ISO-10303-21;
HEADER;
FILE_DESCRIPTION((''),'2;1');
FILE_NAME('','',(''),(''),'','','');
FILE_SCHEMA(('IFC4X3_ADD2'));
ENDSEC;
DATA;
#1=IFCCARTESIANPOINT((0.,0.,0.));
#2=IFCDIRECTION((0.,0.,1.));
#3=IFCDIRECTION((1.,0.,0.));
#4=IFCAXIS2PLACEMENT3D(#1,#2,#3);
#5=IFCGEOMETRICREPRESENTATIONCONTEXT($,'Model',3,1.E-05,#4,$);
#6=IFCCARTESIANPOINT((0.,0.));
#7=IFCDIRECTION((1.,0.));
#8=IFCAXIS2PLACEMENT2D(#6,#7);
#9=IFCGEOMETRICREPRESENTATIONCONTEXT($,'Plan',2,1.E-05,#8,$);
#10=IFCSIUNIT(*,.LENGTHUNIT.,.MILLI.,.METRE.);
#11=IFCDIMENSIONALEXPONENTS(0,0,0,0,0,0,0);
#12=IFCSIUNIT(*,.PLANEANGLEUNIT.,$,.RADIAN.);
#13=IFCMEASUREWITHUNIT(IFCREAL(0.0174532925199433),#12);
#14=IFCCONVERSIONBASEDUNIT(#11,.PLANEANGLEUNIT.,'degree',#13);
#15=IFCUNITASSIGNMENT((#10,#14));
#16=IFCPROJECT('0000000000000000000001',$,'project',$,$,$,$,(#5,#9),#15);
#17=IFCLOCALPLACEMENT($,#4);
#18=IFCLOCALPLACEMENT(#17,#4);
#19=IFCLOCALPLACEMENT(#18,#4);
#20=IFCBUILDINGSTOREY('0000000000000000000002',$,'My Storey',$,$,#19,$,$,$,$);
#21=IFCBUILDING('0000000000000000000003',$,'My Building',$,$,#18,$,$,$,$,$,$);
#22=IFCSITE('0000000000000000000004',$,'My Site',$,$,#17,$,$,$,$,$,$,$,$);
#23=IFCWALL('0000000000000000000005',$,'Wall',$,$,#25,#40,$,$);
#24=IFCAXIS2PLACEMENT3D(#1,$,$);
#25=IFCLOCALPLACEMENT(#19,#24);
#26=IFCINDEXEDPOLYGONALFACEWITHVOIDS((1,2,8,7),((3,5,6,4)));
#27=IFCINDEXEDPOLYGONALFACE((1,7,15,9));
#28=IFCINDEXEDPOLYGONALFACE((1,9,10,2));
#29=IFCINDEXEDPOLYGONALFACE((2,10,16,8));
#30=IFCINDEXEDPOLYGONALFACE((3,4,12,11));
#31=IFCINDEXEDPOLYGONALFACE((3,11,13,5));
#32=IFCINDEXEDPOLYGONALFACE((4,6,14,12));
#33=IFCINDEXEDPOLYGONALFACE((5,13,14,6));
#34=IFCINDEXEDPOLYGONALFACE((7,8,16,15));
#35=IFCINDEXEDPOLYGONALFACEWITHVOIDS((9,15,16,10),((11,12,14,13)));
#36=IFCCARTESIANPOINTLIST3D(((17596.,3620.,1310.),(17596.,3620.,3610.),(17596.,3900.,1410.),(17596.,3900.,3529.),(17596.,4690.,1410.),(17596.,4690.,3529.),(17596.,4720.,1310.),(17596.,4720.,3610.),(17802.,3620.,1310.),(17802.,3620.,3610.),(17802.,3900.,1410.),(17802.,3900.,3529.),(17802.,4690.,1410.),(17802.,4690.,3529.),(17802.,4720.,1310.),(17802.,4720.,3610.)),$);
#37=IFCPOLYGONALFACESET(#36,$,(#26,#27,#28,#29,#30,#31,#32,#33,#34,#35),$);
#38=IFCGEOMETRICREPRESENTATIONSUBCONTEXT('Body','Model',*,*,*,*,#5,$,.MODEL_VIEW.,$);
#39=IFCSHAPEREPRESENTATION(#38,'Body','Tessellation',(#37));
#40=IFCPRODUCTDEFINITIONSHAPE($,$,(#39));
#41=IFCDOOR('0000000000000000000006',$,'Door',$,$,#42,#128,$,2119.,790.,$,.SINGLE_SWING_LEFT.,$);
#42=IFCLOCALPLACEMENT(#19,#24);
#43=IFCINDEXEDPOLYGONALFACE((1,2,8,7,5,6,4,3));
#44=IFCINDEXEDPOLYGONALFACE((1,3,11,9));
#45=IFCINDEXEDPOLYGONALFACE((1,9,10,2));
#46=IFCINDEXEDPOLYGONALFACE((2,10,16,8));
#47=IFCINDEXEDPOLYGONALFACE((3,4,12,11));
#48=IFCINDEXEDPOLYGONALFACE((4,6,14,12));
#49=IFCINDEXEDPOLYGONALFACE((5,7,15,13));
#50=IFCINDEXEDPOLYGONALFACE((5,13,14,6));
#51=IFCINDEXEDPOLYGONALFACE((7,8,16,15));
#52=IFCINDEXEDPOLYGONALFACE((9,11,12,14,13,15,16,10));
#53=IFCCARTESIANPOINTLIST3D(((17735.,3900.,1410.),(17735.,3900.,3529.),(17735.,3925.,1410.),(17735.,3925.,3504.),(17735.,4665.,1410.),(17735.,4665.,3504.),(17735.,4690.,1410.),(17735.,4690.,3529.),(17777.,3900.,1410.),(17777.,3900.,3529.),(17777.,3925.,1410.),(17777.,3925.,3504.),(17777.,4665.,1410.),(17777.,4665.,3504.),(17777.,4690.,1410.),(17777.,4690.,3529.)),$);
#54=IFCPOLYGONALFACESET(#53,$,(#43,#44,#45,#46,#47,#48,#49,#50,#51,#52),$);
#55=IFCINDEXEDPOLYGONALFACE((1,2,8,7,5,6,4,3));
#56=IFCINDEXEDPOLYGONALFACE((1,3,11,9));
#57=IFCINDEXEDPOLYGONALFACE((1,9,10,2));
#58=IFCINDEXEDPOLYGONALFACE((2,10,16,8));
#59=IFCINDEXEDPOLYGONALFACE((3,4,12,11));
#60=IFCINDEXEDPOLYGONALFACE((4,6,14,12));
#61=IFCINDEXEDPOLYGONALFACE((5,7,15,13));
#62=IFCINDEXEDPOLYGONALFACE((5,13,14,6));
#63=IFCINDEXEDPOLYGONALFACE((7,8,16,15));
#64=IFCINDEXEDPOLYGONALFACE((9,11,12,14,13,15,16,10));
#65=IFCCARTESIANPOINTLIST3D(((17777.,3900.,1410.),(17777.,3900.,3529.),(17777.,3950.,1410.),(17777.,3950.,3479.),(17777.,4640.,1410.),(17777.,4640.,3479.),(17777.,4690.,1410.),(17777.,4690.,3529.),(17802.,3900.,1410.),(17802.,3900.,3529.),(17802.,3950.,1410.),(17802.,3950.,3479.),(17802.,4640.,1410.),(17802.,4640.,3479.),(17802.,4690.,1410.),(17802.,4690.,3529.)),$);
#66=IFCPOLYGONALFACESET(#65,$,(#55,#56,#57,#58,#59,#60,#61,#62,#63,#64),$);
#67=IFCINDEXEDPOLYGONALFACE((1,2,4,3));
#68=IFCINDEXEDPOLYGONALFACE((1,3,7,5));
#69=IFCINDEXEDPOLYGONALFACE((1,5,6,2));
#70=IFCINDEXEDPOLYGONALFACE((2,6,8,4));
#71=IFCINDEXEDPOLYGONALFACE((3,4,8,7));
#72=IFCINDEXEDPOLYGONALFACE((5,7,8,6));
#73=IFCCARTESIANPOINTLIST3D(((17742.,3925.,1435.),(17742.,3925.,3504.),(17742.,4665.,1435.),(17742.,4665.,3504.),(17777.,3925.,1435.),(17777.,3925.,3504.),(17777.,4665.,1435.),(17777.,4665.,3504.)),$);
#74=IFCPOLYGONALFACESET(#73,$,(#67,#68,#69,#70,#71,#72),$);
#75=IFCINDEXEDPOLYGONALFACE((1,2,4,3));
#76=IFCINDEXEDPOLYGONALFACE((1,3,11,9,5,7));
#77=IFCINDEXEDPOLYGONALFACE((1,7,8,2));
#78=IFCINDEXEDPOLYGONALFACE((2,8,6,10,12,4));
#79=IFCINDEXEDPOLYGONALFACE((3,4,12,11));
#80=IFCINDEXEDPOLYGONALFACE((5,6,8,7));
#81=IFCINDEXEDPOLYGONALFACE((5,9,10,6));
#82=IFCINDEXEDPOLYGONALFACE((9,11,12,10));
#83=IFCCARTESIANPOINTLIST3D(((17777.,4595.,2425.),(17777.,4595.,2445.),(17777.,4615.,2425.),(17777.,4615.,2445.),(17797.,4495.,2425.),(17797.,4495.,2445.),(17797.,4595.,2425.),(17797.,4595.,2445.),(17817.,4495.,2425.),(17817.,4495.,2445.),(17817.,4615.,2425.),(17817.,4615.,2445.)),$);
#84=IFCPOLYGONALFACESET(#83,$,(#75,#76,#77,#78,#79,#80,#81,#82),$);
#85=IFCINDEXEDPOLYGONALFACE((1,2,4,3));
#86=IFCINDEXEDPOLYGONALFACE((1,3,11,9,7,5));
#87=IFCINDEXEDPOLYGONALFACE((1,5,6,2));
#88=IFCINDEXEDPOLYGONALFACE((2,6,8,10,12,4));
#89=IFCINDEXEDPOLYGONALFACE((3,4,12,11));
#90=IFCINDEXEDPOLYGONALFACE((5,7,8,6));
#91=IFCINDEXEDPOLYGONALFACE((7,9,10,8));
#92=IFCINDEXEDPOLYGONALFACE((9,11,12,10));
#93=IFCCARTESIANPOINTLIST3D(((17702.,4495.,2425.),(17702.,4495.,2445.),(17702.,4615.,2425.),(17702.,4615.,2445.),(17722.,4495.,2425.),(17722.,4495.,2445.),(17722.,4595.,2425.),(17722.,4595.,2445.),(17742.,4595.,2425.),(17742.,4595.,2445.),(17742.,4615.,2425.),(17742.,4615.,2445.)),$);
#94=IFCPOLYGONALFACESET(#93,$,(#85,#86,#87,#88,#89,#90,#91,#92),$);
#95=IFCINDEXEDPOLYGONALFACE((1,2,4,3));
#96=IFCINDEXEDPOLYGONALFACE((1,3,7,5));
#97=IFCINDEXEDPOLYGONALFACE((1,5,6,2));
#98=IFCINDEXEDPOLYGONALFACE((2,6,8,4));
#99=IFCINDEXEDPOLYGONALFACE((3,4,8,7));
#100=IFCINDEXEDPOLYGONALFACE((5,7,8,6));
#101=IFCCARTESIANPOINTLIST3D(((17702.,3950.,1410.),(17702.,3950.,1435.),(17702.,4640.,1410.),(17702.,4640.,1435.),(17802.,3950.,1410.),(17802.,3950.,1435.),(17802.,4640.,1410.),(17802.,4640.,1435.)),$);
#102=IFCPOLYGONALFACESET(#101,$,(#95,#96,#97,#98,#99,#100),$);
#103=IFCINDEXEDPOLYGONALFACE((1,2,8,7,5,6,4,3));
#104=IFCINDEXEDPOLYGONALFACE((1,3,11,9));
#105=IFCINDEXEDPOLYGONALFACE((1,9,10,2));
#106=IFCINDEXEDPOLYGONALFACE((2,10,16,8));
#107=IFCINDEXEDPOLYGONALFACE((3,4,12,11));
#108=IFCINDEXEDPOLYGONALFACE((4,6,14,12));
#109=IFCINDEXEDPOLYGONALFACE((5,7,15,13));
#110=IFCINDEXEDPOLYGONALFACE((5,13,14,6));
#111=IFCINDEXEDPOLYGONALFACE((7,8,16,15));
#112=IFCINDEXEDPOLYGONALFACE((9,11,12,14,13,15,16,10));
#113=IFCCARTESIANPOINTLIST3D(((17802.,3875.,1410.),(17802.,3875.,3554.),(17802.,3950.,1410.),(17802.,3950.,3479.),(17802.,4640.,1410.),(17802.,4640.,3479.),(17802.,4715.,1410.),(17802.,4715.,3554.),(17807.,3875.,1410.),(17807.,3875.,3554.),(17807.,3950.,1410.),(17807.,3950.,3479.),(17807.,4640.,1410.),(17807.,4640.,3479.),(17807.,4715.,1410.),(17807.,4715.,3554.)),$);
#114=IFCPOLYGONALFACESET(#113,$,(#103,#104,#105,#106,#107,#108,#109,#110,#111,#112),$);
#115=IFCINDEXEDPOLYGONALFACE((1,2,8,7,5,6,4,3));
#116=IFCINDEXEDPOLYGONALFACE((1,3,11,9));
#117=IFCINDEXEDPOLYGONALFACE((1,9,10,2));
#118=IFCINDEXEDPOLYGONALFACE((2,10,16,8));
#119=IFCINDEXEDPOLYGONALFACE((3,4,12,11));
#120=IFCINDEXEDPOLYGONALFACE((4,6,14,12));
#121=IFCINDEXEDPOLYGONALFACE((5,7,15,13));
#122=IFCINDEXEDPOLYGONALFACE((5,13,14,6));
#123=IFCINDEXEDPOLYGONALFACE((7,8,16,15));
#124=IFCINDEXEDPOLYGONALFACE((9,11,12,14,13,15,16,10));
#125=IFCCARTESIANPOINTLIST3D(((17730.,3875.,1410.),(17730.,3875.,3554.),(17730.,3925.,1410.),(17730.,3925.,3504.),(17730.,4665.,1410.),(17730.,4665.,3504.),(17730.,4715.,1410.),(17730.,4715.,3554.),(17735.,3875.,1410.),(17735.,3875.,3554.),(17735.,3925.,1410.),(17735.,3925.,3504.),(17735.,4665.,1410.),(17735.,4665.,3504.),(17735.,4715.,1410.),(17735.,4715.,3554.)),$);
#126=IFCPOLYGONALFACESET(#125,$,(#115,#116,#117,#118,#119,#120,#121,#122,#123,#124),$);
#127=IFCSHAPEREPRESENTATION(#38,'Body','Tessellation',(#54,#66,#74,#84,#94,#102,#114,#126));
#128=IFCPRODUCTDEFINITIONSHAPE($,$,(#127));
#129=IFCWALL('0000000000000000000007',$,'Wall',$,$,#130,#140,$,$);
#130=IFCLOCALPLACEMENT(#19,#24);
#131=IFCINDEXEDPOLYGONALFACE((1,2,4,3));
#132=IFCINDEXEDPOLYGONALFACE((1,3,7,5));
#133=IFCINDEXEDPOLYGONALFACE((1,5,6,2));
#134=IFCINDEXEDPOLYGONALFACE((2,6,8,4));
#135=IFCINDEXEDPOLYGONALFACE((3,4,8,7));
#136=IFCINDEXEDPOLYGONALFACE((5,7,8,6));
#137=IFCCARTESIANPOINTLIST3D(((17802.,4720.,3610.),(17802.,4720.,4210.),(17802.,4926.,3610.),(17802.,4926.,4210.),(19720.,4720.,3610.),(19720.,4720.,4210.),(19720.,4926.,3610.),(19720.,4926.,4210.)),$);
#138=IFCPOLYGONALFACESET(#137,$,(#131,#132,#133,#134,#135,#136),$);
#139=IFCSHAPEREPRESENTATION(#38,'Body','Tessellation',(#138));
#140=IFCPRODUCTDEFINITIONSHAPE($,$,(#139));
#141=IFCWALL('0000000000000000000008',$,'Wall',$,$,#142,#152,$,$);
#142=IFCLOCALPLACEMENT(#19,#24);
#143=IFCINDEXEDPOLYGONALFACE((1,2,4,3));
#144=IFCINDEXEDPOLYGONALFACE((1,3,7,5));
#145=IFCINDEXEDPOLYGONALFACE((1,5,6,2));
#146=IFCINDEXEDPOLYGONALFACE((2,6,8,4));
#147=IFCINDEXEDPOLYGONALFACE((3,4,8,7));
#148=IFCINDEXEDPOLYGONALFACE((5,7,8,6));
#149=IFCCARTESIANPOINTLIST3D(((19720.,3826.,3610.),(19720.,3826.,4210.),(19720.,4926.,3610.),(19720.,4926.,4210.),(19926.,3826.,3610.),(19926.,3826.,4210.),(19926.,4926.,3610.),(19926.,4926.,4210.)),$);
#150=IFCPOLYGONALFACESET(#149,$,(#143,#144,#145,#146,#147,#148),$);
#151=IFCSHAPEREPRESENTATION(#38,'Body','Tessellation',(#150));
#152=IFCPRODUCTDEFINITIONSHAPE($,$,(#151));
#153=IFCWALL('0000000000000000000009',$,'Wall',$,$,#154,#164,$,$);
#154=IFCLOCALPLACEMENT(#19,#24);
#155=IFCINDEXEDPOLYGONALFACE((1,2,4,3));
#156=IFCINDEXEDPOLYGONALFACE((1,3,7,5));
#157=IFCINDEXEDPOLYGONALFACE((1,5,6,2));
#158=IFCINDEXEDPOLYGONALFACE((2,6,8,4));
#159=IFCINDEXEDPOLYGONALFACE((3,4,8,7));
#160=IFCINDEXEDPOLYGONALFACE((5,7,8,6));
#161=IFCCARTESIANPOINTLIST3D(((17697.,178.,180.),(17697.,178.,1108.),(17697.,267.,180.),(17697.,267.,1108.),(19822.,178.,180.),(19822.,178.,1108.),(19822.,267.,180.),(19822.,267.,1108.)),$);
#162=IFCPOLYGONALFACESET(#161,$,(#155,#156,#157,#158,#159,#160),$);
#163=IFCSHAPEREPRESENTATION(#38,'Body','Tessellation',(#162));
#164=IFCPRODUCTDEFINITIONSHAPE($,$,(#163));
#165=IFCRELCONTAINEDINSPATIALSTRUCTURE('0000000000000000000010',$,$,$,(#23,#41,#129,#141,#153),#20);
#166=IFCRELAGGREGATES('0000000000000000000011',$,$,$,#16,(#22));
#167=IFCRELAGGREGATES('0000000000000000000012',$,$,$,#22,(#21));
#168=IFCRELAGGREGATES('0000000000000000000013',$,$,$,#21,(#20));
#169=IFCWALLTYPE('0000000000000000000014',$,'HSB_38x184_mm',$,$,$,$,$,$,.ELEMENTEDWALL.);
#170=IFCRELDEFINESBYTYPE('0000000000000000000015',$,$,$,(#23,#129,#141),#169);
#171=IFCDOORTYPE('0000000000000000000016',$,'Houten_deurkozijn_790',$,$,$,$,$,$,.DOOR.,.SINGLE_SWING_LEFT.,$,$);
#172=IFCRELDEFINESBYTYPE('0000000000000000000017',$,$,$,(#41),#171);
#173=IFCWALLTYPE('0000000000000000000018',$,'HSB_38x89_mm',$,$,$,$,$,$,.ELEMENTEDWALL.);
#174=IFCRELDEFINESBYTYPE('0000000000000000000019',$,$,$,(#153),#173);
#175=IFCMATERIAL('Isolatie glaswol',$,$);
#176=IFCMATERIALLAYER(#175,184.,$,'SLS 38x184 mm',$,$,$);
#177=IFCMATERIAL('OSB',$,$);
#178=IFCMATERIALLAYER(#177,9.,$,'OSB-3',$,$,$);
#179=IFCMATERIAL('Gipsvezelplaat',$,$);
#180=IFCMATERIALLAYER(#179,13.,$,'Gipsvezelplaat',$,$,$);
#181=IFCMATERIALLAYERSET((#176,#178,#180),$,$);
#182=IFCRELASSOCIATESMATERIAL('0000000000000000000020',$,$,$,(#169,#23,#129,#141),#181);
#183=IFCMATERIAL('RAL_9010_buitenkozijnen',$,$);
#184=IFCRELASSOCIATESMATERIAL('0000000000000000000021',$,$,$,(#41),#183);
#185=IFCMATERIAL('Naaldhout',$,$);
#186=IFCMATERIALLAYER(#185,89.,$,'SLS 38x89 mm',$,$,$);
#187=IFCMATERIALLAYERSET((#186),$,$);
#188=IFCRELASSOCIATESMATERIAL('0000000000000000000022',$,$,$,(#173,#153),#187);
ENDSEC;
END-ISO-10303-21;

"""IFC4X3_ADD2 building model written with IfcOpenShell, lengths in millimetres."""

from ifc_helpers import new_model, entity, si_unit, converted_unit, frame, origin_with_axes, origin_2d_with_axis, place, context, subcontext, project, spatial, line, indexed_curve, outline, extrude, shape, source, transform, mapped, material, layer, layer_set, layer_usage, type_object, type_shapes, element, fill, save


model = new_model("IFC4X3_ADD2")

# Units and contexts
model_context = context("Model", 3, precision=1e-05, world=origin_with_axes())
plan_context = context("Plan", 2, precision=1e-05, world=origin_2d_with_axis())
body_context_1 = subcontext(model_context, "Body", "Model", "MODEL_VIEW")
body_context_2 = subcontext(plan_context, "Body", "Plan", "PLAN_VIEW")
ifc_project = project(units=[si_unit("LENGTHUNIT", "METRE", prefix="MILLI"), converted_unit("PLANEANGLEUNIT", "degree", entity("IfcReal", 0.0174532925199433), si_unit("PLANEANGLEUNIT", "RADIAN"), dimensions=[0, 0, 0, 0, 0, 0, 0])], contexts=[model_context, plan_context])

# Site, building, storey
site_placement = place(None, origin_with_axes())
site = spatial("IfcSite", under=ifc_project, at=site_placement, Name="My Site")
building_placement = place(site_placement, origin_with_axes())
building = spatial("IfcBuilding", under=site, at=building_placement, Name="My Building")
storey_placement = place(building_placement, origin_with_axes())
storey = spatial("IfcBuildingStorey", under=building, at=storey_placement, Name="My Storey")

# Shared definitions
ifc_material_1 = material(Name="Isolatie glaswol")

# Shared definitions
ifc_layer_1 = layer(ifc_material_1, 184.0, Name="SLS 38x184 mm")
ifc_material_2 = material(Name="OSB")
ifc_layer_2 = layer(ifc_material_2, 9.0, Name="OSB-3")
ifc_material_3 = material(Name="Gipsvezelplaat")
ifc_layer_3 = layer(ifc_material_3, 13.0, Name="Gipsvezelplaat")
ifc_layer_set_1 = layer_set([ifc_layer_1, ifc_layer_2, ifc_layer_3])
wall_type_1 = type_object("IfcWallType", Name="HSB_38x184_mm", PredefinedType="ELEMENTEDWALL", material=ifc_layer_set_1)
ifc_material_4 = material(Name="RAL_9010_buitenkozijnen")

# Wall, opening, door
ifc_layer_usage_1 = layer_usage(ifc_layer_set_1, "AXIS2", "POSITIVE", 0.0)
wall_1_placement = place(storey_placement, frame((17802.0, 3620.0, 1310.0), z_axis=(0.0, 0.0, 1.0), x_axis=(0.0, 1.0, 0.0)))
wall_1 = element("IfcWall", 1, at=wall_1_placement, inside=storey, type_object=wall_type_1, material=ifc_layer_usage_1, Name="Wall", context=body_context_1, shape_type="SweptSolid", body=[
    extrude(outline(indexed_curve([(0.0, 0.0), (0.0, 206.0), (1100.0, 206.0), (1100.0, 0.0), (0.0, 0.0)], self_intersect=False)), origin_with_axes(), (0.0, 0.0, 1.0), 2300.0),
])
shared_shape_1 = source(origin_with_axes(), body_context_1, "Body", "SweptSolid", [
    extrude(outline(indexed_curve([(0.0, 0.0), (790.0, 0.0), (790.0, 2119.0), (0.0, 2119.0)], segments=[line(1, 2, 3, 4, 1)])), frame((0.0, -600.0, 0.0), z_axis=(0.0, -1.0, 0.0), x_axis=(1.0, 0.0, 0.0)), (0.0, 0.0, -1.0), 1200.0),
])
opening_1_placement = place(wall_1_placement, frame((280.0, 0.0, 100.0), z_axis=(0.0, 0.0, 1.0), x_axis=(1.0, 0.0, 0.0)))
opening_1 = element("IfcOpeningElement", 2, at=opening_1_placement, cuts=wall_1, PredefinedType="OPENING", context=body_context_1, shape_type="MappedRepresentation", body=[
    mapped(shared_shape_1, transform((0.0, 0.0, 0.0), x_axis=(1.0, 0.0, 0.0), y_axis=(0.0, 1.0, 0.0), z_axis=(0.0, 0.0, 1.0), scale=1.0)),
])
door_type_1 = type_object("IfcDoorType", Name="Houten_deurkozijn_790", OperationType="SINGLE_SWING_LEFT", PredefinedType="DOOR")
shared_shape_2 = source(origin_with_axes(), body_context_1, "Body", "SweptSolid", [
    extrude(outline(indexed_curve([(0.0, 0.0), (0.0, 2119.0), (790.0, 2119.0), (790.0, 0.0), (765.0, 0.0), (765.0, 2094.0), (25.0, 2094.0), (25.0, 0.0)], segments=[line(1, 2, 3, 4, 5, 6, 7, 8, 1)])), frame((0.0, 25.0, 0.0), z_axis=(0.0, -1.0, 0.0), x_axis=(1.0, 0.0, 0.0)), (0.0, 0.0, -1.0), 42.0),
    extrude(outline(indexed_curve([(0.0, 0.0), (0.0, 2119.0), (790.0, 2119.0), (790.0, 0.0), (740.0, 0.0), (740.0, 2069.0), (50.0, 2069.0), (50.0, 0.0)], segments=[line(1, 2, 3, 4, 5, 6, 7, 8, 1)])), frame((0.0, 0.0, 0.0), z_axis=(0.0, -1.0, 0.0), x_axis=(1.0, 0.0, 0.0)), (0.0, 0.0, -1.0), 25.0),
    extrude(outline(indexed_curve([(0.0, 0.0), (740.0, 0.0), (740.0, 35.0), (0.0, 35.0)], segments=[line(1, 2, 3, 4, 1)])), frame((25.0, 25.0, 25.0), z_axis=(0.0, 0.0, 1.0), x_axis=(1.0, 0.0, 0.0)), (0.0, 0.0, 1.0), 2069.0),
    extrude(outline(indexed_curve([(0.0, 0.0), (0.0, -40.0), (-120.0, -40.0), (-120.0, -20.0), (-20.0, -20.0), (-20.0, 0.0)], segments=[line(1, 2, 3, 4, 5, 6, 1)])), frame((715.0, 25.0, 1015.0), z_axis=(0.0, 0.0, 1.0), x_axis=(1.0, 0.0, 0.0)), (0.0, 0.0, 1.0), 20.0),
    extrude(outline(indexed_curve([(0.0, 0.0), (0.0, 40.0), (-120.0, 40.0), (-120.0, 20.0), (-20.0, 20.0), (-20.0, 0.0)], segments=[line(1, 2, 3, 4, 5, 6, 1)])), frame((715.0, 60.0, 1015.0), z_axis=(0.0, 0.0, 1.0), x_axis=(1.0, 0.0, 0.0)), (0.0, 0.0, 1.0), 20.0),
    extrude(outline(indexed_curve([(0.0, 0.0), (690.0, 0.0), (690.0, 100.0), (0.0, 100.0)], segments=[line(1, 2, 3, 4, 1)])), frame((50.0, 0.0, 0.0), z_axis=(0.0, 0.0, 1.0), x_axis=(1.0, 0.0, 0.0)), (0.0, 0.0, 1.0), 25.0),
    extrude(outline(indexed_curve([(0.0, 0.0), (0.0, 2144.0), (840.0, 2144.0), (840.0, 0.0), (765.0, 0.0), (765.0, 2069.0), (75.0, 2069.0), (75.0, 0.0)], segments=[line(1, 2, 3, 4, 5, 6, 7, 8, 1)])), frame((-25.0, -5.0, 0.0), z_axis=(0.0, -1.0, 0.0), x_axis=(1.0, 0.0, 0.0)), (0.0, 0.0, -1.0), 5.0),
    extrude(outline(indexed_curve([(0.0, 0.0), (0.0, 2144.0), (840.0, 2144.0), (840.0, 0.0), (790.0, 0.0), (790.0, 2094.0), (50.0, 2094.0), (50.0, 0.0)], segments=[line(1, 2, 3, 4, 5, 6, 7, 8, 1)])), frame((-25.0, 67.0, 0.0), z_axis=(0.0, -1.0, 0.0), x_axis=(1.0, 0.0, 0.0)), (0.0, 0.0, -1.0), 5.0),
])
shared_shape_3 = source(origin_with_axes(), body_context_2, "Body", "Curve2D", [
    entity("IfcIndexedPolyCurve", entity("IfcCartesianPointList2D", [[0.0, 0.0], [0.0, 67.0], [25.0, 67.0], [25.0, 25.0], [50.0, 25.0], [50.0, 0.0]]), [entity("IfcLineIndex", [1, 2, 3, 4, 5, 6, 1])]),
    entity("IfcIndexedPolyCurve", entity("IfcCartesianPointList2D", [[790.0, 0.0], [790.0, 67.0], [765.0, 67.0], [765.0, 25.0], [740.0, 25.0], [740.0, 0.0]]), [entity("IfcLineIndex", [1, 2, 3, 4, 5, 6, 1])]),
    entity("IfcTrimmedCurve", entity("IfcEllipse", entity("IfcAxis2Placement2D", entity("IfcCartesianPoint", [60.0, 67.0]), entity("IfcDirection", [1.0, 0.0])), 705.0, 740.0), [entity("IfcCartesianPoint", [765.0, 67.0])], [entity("IfcCartesianPoint", [60.0, 807.0])], True, "CARTESIAN"),
    entity("IfcIndexedPolyCurve", entity("IfcCartesianPointList2D", [[25.0, 67.0], [60.0, 67.0], [60.0, 807.0], [25.0, 807.0]]), [entity("IfcLineIndex", [1, 2, 3, 4, 1])]),
])
type_shapes(door_type_1, [shared_shape_2, shared_shape_3])
door_1_placement = place(opening_1_placement, frame((0.0, 0.0, 0.0), z_axis=(0.0, 0.0, 1.0), x_axis=(1.0, 0.0, 0.0)))
door_1 = element("IfcDoor", 3, at=door_1_placement, inside=storey, type_object=door_type_1, material=ifc_material_4, Name="Door", OperationType="SINGLE_SWING_LEFT", OverallHeight=2119.0, OverallWidth=790.0, shapes=[
    shape(body_context_1, "Body", "MappedRepresentation", [mapped(shared_shape_2, transform((0.0, 0.0, 0.0), x_axis=(1.0, 0.0, 0.0), y_axis=(0.0, 1.0, 0.0), z_axis=(0.0, 0.0, 1.0), scale=1.0))]),
    shape(body_context_2, "Body", "MappedRepresentation", [mapped(shared_shape_3, transform((0.0, 0.0, 0.0), x_axis=(1.0, 0.0, 0.0), y_axis=(0.0, 1.0, 0.0), z_axis=(0.0, 0.0, 1.0), scale=1.0))]),
])
fill(opening_1, door_1)

# Walls
ifc_layer_usage_2 = layer_usage(ifc_layer_set_1, "AXIS2", "POSITIVE", 0.0)
wall_2_placement = place(storey_placement, frame((17802.0, 4720.0, 3610.0), z_axis=(0.0, 0.0, 1.0), x_axis=(1.0, 0.0, 0.0)))
element("IfcWall", 4, at=wall_2_placement, inside=storey, type_object=wall_type_1, material=ifc_layer_usage_2, Name="Wall", context=body_context_1, shape_type="SweptSolid", body=[
    extrude(outline(indexed_curve([(0.0, 0.0), (0.0, 206.0), (1918.0, 206.0), (1918.0, 0.0), (0.0, 0.0)], self_intersect=False)), origin_with_axes(), (0.0, 0.0, 1.0), 600.0),
])
ifc_layer_usage_3 = layer_usage(ifc_layer_set_1, "AXIS2", "POSITIVE", 0.0)
wall_3_placement = place(storey_placement, frame((19926.0, 3826.0, 3610.0), z_axis=(0.0, 0.0, 1.0), x_axis=(0.0, 1.0, 0.0)))
element("IfcWall", 5, at=wall_3_placement, inside=storey, type_object=wall_type_1, material=ifc_layer_usage_3, Name="Wall", context=body_context_1, shape_type="SweptSolid", body=[
    extrude(outline(indexed_curve([(0.0, 0.0), (0.0, 206.0), (1100.0, 206.0), (1100.0, 0.0), (0.0, 0.0)], self_intersect=False)), origin_with_axes(), (0.0, 0.0, 1.0), 600.0),
])
ifc_material_5 = material(Name="Naaldhout")
ifc_layer_4 = layer(ifc_material_5, 89.0, Name="SLS 38x89 mm")
ifc_layer_set_2 = layer_set([ifc_layer_4])
ifc_layer_usage_4 = layer_usage(ifc_layer_set_2, "AXIS2", "POSITIVE", 0.0)
wall_type_2 = type_object("IfcWallType", Name="HSB_38x89_mm", PredefinedType="ELEMENTEDWALL", material=ifc_layer_set_2)
wall_4_placement = place(storey_placement, frame((17697.0, 178.0, 180.0), z_axis=(0.0, 0.0, 1.0), x_axis=(1.0, 0.0, 0.0)))
element("IfcWall", 6, at=wall_4_placement, inside=storey, type_object=wall_type_2, material=ifc_layer_usage_4, Name="Wall", context=body_context_1, shape_type="SweptSolid", body=[
    extrude(outline(indexed_curve([(0.0, 0.0), (0.0, 89.0), (2125.0, 89.0), (2125.0, 0.0), (0.0, 0.0)], self_intersect=False)), origin_with_axes(), (0.0, 0.0, 1.0), 928.0),
])

save(model, "model.ifc")
